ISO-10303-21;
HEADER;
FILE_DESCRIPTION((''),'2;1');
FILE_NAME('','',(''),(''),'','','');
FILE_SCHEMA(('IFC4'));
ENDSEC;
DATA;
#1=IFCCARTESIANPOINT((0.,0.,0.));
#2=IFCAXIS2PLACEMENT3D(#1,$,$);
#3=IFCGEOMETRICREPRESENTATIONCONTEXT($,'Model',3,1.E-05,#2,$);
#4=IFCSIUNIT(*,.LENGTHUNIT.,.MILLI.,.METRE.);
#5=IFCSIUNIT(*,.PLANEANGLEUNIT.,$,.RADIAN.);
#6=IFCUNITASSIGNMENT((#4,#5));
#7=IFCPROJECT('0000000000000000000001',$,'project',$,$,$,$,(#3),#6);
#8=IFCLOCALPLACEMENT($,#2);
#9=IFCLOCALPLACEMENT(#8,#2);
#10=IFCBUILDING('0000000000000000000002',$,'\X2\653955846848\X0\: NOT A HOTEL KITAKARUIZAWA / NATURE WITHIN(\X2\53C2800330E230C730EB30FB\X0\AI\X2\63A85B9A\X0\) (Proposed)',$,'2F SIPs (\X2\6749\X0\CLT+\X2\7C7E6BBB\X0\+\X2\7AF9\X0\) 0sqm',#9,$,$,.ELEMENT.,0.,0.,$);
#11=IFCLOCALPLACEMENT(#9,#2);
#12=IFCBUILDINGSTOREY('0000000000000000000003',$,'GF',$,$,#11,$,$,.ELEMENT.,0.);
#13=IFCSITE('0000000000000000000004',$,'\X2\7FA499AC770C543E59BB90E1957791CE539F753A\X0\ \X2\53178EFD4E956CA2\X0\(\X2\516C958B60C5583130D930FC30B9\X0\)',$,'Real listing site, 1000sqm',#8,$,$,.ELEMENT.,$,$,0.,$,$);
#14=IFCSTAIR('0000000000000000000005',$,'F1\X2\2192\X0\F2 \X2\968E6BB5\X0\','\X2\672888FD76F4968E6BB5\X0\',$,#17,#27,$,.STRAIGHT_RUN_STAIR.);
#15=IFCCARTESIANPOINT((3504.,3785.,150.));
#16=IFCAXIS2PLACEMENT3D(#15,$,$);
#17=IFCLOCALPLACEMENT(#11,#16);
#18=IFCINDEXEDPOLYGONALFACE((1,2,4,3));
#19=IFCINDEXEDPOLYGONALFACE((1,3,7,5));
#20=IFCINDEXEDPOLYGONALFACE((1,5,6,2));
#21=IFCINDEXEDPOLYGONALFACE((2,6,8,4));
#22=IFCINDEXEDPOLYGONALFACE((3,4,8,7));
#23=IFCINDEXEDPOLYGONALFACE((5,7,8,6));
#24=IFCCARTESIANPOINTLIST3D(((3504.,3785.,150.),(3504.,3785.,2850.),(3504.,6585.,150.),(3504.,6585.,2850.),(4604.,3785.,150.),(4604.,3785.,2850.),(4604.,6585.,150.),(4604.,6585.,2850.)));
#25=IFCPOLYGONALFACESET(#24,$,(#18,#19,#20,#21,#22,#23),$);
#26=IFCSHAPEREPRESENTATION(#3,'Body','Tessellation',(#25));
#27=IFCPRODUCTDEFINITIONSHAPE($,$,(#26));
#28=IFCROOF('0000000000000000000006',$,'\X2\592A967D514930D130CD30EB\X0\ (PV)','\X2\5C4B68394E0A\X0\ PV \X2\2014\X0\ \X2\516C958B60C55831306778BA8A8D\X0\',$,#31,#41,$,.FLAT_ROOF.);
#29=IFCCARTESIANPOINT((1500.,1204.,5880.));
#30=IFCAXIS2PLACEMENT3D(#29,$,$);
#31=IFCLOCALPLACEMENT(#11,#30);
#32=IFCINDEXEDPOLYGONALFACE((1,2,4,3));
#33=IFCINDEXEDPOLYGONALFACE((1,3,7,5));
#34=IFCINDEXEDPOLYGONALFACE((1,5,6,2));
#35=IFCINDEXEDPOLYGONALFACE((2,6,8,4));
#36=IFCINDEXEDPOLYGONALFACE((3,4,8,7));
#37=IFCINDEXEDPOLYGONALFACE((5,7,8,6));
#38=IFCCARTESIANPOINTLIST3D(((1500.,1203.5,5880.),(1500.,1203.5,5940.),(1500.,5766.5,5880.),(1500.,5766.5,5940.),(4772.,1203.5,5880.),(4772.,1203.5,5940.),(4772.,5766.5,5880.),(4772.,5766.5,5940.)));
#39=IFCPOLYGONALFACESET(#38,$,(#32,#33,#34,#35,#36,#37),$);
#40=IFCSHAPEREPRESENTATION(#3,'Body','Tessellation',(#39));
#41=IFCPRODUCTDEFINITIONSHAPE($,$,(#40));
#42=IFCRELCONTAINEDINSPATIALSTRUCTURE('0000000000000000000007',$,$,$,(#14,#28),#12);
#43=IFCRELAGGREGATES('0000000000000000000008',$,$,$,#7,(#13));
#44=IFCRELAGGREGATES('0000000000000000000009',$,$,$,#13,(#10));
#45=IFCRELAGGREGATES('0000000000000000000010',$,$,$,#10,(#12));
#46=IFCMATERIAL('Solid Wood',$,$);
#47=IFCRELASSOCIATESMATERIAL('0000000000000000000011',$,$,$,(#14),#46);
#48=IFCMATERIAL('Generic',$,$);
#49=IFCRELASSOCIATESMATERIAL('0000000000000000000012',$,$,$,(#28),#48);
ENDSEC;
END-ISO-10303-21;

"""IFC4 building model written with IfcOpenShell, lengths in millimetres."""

from ifc_helpers import new_model, si_unit, frame, frame_2d, origin, place, context, project, spatial, rectangle, extrude, material, element, save


model = new_model("IFC4")

# Units and contexts
model_context = context("Model", 3, precision=1e-05, world=origin())
ifc_project = project(units=[si_unit("LENGTHUNIT", "METRE", prefix="MILLI"), si_unit("PLANEANGLEUNIT", "RADIAN")], contexts=[model_context])

# Site, building, storey
site_placement = place(None, origin())
site = spatial("IfcSite", under=ifc_project, at=site_placement, Name="群馬県吾妻郡長野原町 北軽井沢(公開情報ベース)", ObjectType="Real listing site, 1000sqm", CompositionType="ELEMENT", RefElevation=0.0)
building_placement = place(site_placement, origin())
building = spatial("IfcBuilding", under=site, at=building_placement, Name="改善案: NOT A HOTEL KITAKARUIZAWA / NATURE WITHIN(参考モデル・AI推定) (Proposed)", ObjectType="2F SIPs (杉CLT+籾殻+竹) 0sqm", CompositionType="ELEMENT", ElevationOfRefHeight=0.0, ElevationOfTerrain=0.0)
storey_placement = place(building_placement, origin())
storey = spatial("IfcBuildingStorey", under=building, at=storey_placement, Name="GF", CompositionType="ELEMENT", Elevation=0.0)

# Shared definitions
ifc_material_1 = material(Name="Generic")

# Stair
ifc_material_2 = material(Name="Solid Wood")
stair_placement = place(storey_placement, frame((3504.0, 3785.0, 150.0)))
element("IfcStair", 1, at=stair_placement, inside=storey, material=ifc_material_2, Name="F1→F2 階段", Description="木製直階段", PredefinedType="STRAIGHT_RUN_STAIR", context=model_context, shape_type="SweptSolid", body=[
    extrude(rectangle(XDim=1100.0, YDim=2800.0, at=frame_2d((550.0, 1400.0))), frame((3504.0, 3785.0, 150.0)), (0.0, 0.0, 1.0), 2700.0),
])

# Roof
roof_placement = place(storey_placement, frame((1500.0, 1204.0, 5880.0)))
element("IfcRoof", 2, at=roof_placement, inside=storey, material=ifc_material_1, Name="太陽光パネル (PV)", Description="屋根上 PV — 公開情報で確認", PredefinedType="FLAT_ROOF", context=model_context, shape_type="SweptSolid", body=[
    extrude(rectangle(XDim=3272.0, YDim=4563.0, at=frame_2d((1636.0, 2281.0))), frame((1500.0, 1204.0, 5880.0)), (0.0, 0.0, 1.0), 60.0),
])

save(model, "model.ifc")
